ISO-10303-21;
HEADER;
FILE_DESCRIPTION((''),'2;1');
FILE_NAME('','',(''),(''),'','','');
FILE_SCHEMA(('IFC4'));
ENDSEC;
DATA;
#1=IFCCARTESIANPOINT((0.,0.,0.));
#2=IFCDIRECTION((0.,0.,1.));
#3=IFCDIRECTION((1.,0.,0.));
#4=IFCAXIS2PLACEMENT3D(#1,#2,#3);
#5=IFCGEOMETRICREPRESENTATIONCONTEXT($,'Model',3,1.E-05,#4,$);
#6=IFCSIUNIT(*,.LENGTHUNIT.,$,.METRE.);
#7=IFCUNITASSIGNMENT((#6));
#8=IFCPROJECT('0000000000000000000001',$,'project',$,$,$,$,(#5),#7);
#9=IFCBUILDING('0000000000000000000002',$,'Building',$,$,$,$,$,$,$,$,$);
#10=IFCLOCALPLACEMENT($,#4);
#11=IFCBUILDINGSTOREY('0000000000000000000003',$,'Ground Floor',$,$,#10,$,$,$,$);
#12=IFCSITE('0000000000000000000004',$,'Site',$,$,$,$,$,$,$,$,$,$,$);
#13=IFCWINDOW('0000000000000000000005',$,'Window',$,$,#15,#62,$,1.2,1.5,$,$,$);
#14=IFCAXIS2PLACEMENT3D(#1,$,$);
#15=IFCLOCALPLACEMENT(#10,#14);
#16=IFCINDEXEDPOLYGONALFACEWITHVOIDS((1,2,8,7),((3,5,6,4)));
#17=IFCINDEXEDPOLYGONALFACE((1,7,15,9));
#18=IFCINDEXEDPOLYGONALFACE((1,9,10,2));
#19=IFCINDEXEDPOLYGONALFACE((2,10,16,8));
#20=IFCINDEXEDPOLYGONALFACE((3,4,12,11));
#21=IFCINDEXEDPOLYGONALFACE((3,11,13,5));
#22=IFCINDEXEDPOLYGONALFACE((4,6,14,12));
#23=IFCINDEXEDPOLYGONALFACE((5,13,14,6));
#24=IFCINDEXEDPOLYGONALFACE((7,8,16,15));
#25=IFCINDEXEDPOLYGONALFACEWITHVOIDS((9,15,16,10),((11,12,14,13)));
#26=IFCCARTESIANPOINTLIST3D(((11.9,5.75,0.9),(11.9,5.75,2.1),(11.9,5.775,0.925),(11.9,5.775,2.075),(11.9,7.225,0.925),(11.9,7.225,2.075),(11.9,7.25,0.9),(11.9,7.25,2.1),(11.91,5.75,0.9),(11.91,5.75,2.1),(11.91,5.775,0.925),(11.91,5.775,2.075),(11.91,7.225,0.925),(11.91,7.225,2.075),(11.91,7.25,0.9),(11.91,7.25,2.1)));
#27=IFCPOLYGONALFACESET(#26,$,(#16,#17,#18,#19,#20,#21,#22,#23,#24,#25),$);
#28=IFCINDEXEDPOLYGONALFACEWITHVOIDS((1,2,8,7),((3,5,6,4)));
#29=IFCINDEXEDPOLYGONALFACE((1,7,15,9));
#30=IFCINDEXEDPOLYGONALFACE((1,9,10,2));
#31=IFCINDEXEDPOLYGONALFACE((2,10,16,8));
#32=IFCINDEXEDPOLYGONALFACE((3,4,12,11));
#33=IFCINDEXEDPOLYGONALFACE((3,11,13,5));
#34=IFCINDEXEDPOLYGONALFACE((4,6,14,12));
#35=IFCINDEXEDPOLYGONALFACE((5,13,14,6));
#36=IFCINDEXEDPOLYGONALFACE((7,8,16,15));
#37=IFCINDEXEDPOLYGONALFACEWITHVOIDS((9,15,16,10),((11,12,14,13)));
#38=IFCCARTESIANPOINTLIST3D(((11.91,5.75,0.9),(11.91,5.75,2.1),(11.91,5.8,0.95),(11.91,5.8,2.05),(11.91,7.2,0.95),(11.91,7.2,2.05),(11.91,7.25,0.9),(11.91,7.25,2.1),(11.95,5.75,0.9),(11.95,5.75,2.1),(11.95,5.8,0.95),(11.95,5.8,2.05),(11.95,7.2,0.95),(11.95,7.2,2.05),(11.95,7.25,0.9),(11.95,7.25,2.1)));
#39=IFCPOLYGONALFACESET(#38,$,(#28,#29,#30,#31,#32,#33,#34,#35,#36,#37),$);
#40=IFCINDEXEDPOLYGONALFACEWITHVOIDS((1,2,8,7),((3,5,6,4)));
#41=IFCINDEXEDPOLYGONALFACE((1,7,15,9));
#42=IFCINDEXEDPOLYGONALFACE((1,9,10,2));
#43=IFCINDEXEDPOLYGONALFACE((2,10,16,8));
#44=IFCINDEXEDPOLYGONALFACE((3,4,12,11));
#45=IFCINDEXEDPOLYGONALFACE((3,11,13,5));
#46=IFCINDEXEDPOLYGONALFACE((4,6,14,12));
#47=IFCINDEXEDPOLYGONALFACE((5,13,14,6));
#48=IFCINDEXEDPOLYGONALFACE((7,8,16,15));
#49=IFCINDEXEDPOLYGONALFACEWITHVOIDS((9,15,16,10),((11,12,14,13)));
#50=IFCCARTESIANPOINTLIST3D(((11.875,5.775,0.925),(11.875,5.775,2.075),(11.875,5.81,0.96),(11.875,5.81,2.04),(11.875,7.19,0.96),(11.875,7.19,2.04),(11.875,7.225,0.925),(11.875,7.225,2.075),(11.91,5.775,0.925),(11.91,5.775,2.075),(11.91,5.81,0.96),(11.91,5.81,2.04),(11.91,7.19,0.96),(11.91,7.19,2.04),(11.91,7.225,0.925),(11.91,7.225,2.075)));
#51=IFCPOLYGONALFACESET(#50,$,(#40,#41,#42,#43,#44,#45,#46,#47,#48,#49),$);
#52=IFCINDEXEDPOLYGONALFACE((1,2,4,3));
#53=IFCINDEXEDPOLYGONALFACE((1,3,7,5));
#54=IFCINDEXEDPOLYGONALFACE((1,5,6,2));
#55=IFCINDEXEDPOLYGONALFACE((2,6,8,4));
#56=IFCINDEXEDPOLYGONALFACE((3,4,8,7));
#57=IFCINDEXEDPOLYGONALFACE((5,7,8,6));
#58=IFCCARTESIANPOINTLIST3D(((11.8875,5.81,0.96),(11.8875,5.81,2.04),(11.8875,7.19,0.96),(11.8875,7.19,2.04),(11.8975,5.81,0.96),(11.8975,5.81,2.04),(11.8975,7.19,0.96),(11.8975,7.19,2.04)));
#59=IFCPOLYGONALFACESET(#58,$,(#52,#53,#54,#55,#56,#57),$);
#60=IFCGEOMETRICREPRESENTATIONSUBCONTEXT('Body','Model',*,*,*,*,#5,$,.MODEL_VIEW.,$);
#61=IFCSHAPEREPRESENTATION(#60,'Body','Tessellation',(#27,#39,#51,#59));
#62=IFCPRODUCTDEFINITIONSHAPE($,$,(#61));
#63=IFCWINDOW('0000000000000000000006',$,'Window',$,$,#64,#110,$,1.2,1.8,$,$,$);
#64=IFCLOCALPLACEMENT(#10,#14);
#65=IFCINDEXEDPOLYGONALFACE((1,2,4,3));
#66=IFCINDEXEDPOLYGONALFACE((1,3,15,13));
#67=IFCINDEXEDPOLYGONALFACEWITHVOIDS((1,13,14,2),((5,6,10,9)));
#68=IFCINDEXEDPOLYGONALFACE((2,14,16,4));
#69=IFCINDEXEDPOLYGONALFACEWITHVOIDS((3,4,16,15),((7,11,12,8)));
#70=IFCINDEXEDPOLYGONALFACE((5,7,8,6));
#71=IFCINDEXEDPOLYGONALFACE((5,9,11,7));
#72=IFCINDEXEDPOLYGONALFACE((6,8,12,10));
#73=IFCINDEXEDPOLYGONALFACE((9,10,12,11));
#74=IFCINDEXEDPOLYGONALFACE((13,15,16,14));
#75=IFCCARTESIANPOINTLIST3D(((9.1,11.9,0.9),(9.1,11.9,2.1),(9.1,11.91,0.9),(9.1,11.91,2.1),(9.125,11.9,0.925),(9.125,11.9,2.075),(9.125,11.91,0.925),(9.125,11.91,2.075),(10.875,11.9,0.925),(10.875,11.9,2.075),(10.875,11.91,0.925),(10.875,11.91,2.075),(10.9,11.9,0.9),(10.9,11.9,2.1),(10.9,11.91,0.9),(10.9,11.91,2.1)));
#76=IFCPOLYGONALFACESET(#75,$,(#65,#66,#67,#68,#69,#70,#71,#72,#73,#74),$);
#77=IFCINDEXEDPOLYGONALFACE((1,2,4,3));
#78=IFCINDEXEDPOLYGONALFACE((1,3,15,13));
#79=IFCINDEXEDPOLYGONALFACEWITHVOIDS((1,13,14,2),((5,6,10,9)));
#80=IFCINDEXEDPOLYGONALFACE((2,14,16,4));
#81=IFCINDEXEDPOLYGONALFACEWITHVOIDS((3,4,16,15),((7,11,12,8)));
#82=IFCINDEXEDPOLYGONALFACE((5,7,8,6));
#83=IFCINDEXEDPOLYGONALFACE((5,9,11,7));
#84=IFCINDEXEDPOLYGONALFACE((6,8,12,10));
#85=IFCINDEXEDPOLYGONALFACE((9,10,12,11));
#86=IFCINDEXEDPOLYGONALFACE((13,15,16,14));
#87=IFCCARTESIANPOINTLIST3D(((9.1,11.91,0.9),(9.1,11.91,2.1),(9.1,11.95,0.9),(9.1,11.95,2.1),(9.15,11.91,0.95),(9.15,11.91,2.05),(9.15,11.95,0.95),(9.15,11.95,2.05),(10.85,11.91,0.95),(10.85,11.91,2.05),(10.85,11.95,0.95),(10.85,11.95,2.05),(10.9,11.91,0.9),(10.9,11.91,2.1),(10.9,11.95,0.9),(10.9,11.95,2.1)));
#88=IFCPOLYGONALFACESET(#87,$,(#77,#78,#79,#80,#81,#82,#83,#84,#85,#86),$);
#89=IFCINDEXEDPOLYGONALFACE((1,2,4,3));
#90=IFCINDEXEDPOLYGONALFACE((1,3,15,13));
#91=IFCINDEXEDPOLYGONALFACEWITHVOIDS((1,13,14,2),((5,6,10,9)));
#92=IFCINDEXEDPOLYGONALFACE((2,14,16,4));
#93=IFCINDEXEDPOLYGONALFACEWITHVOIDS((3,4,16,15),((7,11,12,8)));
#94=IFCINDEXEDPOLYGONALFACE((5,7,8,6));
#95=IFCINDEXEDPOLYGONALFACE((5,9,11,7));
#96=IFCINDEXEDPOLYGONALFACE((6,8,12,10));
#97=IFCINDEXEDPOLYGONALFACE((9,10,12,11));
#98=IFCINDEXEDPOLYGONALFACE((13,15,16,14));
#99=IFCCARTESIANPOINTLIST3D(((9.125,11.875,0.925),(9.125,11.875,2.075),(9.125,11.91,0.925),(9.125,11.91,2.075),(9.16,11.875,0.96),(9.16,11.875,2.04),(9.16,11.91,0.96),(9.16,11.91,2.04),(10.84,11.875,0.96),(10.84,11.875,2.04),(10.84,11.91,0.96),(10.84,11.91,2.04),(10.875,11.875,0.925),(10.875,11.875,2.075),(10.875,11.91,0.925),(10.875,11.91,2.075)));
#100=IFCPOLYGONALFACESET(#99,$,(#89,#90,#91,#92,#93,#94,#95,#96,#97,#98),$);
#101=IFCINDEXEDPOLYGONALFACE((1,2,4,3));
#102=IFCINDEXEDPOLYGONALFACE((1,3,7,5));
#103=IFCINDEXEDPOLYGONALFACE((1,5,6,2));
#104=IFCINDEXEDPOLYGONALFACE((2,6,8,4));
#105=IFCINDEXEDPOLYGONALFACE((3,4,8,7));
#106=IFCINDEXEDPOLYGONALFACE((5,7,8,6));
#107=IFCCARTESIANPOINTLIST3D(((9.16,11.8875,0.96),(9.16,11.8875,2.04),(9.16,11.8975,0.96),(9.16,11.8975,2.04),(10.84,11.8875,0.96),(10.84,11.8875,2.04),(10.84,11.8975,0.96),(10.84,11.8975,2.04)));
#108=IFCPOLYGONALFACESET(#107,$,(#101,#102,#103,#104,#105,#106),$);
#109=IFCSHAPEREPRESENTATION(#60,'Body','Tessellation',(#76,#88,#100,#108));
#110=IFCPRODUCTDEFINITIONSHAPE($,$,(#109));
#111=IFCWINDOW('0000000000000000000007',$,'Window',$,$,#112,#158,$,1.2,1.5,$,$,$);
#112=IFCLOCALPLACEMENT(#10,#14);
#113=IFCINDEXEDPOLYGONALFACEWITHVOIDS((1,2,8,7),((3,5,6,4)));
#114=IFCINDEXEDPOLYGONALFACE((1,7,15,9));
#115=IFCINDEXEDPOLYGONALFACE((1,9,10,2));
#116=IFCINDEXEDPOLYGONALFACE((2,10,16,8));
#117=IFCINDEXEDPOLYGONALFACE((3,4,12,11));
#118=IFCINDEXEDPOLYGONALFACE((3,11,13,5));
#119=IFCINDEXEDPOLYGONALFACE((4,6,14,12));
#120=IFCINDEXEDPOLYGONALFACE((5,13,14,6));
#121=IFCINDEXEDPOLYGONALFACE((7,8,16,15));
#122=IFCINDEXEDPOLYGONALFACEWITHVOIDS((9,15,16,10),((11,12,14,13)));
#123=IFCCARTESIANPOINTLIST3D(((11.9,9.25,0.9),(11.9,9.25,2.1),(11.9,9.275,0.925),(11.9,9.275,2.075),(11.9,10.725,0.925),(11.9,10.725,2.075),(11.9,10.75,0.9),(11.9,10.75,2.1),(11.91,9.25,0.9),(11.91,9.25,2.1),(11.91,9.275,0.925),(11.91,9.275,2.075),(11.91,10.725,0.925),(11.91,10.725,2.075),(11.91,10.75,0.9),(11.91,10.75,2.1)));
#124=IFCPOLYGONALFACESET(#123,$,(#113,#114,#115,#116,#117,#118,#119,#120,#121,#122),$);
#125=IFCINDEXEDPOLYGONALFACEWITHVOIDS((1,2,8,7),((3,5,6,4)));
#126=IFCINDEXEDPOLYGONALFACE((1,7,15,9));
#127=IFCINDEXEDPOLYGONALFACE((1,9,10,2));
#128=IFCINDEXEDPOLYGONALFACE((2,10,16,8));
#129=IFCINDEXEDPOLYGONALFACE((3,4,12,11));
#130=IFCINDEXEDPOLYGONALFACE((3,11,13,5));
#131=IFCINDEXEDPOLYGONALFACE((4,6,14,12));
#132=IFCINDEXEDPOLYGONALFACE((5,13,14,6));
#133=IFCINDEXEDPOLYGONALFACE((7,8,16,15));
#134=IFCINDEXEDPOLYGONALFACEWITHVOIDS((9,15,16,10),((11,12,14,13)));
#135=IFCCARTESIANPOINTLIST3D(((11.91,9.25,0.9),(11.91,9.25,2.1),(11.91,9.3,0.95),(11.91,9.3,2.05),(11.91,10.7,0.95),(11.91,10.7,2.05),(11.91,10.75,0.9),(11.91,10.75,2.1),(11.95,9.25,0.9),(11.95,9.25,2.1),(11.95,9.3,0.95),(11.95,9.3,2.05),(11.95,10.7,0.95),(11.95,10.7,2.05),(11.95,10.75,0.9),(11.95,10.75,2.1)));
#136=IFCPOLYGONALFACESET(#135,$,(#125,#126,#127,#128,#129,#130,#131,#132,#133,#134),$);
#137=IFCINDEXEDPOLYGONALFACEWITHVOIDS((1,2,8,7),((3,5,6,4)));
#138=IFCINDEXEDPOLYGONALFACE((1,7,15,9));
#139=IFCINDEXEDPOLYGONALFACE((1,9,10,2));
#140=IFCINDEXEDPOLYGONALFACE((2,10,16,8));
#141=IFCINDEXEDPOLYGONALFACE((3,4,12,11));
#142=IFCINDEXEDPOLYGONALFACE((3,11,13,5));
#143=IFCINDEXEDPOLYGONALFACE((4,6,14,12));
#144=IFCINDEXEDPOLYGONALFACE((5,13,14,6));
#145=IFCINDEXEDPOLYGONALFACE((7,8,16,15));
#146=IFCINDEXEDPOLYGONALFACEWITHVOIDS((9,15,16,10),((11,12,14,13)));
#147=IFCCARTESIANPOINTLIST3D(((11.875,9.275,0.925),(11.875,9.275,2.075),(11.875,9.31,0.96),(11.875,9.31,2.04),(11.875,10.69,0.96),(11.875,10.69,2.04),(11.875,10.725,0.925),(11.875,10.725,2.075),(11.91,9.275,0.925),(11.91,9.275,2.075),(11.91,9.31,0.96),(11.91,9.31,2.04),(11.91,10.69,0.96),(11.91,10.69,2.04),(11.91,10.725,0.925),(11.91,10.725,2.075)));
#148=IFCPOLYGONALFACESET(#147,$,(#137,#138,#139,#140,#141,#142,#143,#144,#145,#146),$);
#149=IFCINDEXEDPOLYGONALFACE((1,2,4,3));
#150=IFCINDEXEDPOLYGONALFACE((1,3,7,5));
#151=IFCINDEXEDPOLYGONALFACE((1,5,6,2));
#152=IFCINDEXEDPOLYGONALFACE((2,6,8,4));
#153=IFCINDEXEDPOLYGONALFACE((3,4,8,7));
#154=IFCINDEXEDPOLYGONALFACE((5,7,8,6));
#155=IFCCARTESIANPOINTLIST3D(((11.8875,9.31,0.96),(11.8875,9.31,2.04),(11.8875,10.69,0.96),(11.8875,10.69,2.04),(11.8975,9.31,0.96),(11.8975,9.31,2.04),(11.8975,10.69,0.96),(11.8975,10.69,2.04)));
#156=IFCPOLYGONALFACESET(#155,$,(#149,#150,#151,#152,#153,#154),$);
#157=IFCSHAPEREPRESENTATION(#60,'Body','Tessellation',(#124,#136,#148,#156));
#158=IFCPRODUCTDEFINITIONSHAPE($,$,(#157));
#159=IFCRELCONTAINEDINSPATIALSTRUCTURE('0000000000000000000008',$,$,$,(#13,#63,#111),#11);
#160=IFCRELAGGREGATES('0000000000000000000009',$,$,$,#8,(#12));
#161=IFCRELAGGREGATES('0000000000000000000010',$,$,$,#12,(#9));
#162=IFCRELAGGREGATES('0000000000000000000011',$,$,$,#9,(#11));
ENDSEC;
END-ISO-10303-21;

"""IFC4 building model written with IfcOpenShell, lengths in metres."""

from ifc_helpers import new_model, si_unit, frame, origin_with_axes, place, context, subcontext, project, spatial, line, indexed_curve, outline, extrude, element, save


model = new_model("IFC4")

# Units and contexts
model_context = context("Model", 3, precision=1e-05, world=origin_with_axes())
body_context = subcontext(model_context, "Body", "Model", "MODEL_VIEW")
ifc_project = project(units=[si_unit("LENGTHUNIT", "METRE")], contexts=[model_context])

# Site, building, storey
site = spatial("IfcSite", under=ifc_project, Name="Site")
building = spatial("IfcBuilding", under=site, Name="Building")
storey_placement = place(None, origin_with_axes())
storey = spatial("IfcBuildingStorey", under=building, at=storey_placement, Name="Ground Floor")

# Windows
for number, where, z_axis, x_axis, name in (
    (1, (12.0, 5.75, 0.9), (0.0, 0.0, 1.0), (0.0, 1.0, 0.0), "Window"),
):
    element("IfcWindow", number, at=place(storey_placement, frame(where, z_axis=z_axis, x_axis=x_axis)), inside=storey, Name=name, OverallHeight=1.2, OverallWidth=1.5, context=body_context, shape_type="SweptSolid", body=[
        extrude(outline(indexed_curve([(0.0, 0.0), (1.5, 0.0), (1.5, 1.2), (0.0, 1.2)], segments=[line(1, 2, 3, 4, 1)]), holes=[indexed_curve([(0.025, 0.025), (1.475, 0.025), (1.475, 1.175), (0.025, 1.175)], segments=[line(1, 2, 3, 4, 1)])]), frame((0.0, 0.09, 0.0), z_axis=(0.0, -1.0, 0.0), x_axis=(1.0, 0.0, 0.0)), (0.0, 0.0, -1.0), 0.01),
        extrude(outline(indexed_curve([(0.0, 0.0), (1.5, 0.0), (1.5, 1.2), (0.0, 1.2)], segments=[line(1, 2, 3, 4, 1)]), holes=[indexed_curve([(0.05, 0.05), (1.45, 0.05), (1.45, 1.15), (0.05, 1.15)], segments=[line(1, 2, 3, 4, 1)])]), frame((0.0, 0.05, 0.0), z_axis=(0.0, -1.0, 0.0), x_axis=(1.0, 0.0, 0.0)), (0.0, 0.0, -1.0), 0.04),
        extrude(outline(indexed_curve([(0.0, 0.0), (1.45, 0.0), (1.45, 1.15), (0.0, 1.15)], segments=[line(1, 2, 3, 4, 1)]), holes=[indexed_curve([(0.035, 0.035), (1.415, 0.035), (1.415, 1.115), (0.035, 1.115)], segments=[line(1, 2, 3, 4, 1)])]), frame((0.025, 0.09, 0.025), z_axis=(0.0, -1.0, 0.0), x_axis=(1.0, 0.0, 0.0)), (0.0, 0.0, -1.0), 0.035),
        extrude(outline(indexed_curve([(0.035, 0.035), (1.415, 0.035), (1.415, 1.115), (0.035, 1.115)], segments=[line(1, 2, 3, 4, 1)])), frame((0.025, 0.1025, 0.025), z_axis=(0.0, -1.0, 0.0), x_axis=(1.0, 0.0, 0.0)), (0.0, 0.0, -1.0), 0.01),
    ])
window_1_placement = place(storey_placement, frame((10.9, 12.0, 0.9), z_axis=(0.0, 0.0, 1.0), x_axis=(-1.0, 0.0, 0.0)))
element("IfcWindow", 2, at=window_1_placement, inside=storey, Name="Window", OverallHeight=1.2, OverallWidth=1.8, context=body_context, shape_type="SweptSolid", body=[
    extrude(outline(indexed_curve([(0.0, 0.0), (1.8, 0.0), (1.8, 1.2), (0.0, 1.2)], segments=[line(1, 2, 3, 4, 1)]), holes=[indexed_curve([(0.025, 0.025), (1.775, 0.025), (1.775, 1.175), (0.025, 1.175)], segments=[line(1, 2, 3, 4, 1)])]), frame((0.0, 0.09, 0.0), z_axis=(0.0, -1.0, 0.0), x_axis=(1.0, 0.0, 0.0)), (0.0, 0.0, -1.0), 0.01),
    extrude(outline(indexed_curve([(0.0, 0.0), (1.8, 0.0), (1.8, 1.2), (0.0, 1.2)], segments=[line(1, 2, 3, 4, 1)]), holes=[indexed_curve([(0.05, 0.05), (1.75, 0.05), (1.75, 1.15), (0.05, 1.15)], segments=[line(1, 2, 3, 4, 1)])]), frame((0.0, 0.05, 0.0), z_axis=(0.0, -1.0, 0.0), x_axis=(1.0, 0.0, 0.0)), (0.0, 0.0, -1.0), 0.04),
    extrude(outline(indexed_curve([(0.0, 0.0), (1.75, 0.0), (1.75, 1.15), (0.0, 1.15)], segments=[line(1, 2, 3, 4, 1)]), holes=[indexed_curve([(0.035, 0.035), (1.715, 0.035), (1.715, 1.115), (0.035, 1.115)], segments=[line(1, 2, 3, 4, 1)])]), frame((0.025, 0.09, 0.025), z_axis=(0.0, -1.0, 0.0), x_axis=(1.0, 0.0, 0.0)), (0.0, 0.0, -1.0), 0.035),
    extrude(outline(indexed_curve([(0.035, 0.035), (1.715, 0.035), (1.715, 1.115), (0.035, 1.115)], segments=[line(1, 2, 3, 4, 1)])), frame((0.025, 0.1025, 0.025), z_axis=(0.0, -1.0, 0.0), x_axis=(1.0, 0.0, 0.0)), (0.0, 0.0, -1.0), 0.01),
])
window_2_placement = place(storey_placement, frame((12.0, 9.25, 0.9), z_axis=(0.0, 0.0, 1.0), x_axis=(0.0, 1.0, 0.0)))
element("IfcWindow", 3, at=window_2_placement, inside=storey, Name="Window", OverallHeight=1.2, OverallWidth=1.5, context=body_context, shape_type="SweptSolid", body=[
    extrude(outline(indexed_curve([(0.0, 0.0), (1.5, 0.0), (1.5, 1.2), (0.0, 1.2)], segments=[line(1, 2, 3, 4, 1)]), holes=[indexed_curve([(0.025, 0.025), (1.475, 0.025), (1.475, 1.175), (0.025, 1.175)], segments=[line(1, 2, 3, 4, 1)])]), frame((0.0, 0.09, 0.0), z_axis=(0.0, -1.0, 0.0), x_axis=(1.0, 0.0, 0.0)), (0.0, 0.0, -1.0), 0.01),
    extrude(outline(indexed_curve([(0.0, 0.0), (1.5, 0.0), (1.5, 1.2), (0.0, 1.2)], segments=[line(1, 2, 3, 4, 1)]), holes=[indexed_curve([(0.05, 0.05), (1.45, 0.05), (1.45, 1.15), (0.05, 1.15)], segments=[line(1, 2, 3, 4, 1)])]), frame((0.0, 0.05, 0.0), z_axis=(0.0, -1.0, 0.0), x_axis=(1.0, 0.0, 0.0)), (0.0, 0.0, -1.0), 0.04),
    extrude(outline(indexed_curve([(0.0, 0.0), (1.45, 0.0), (1.45, 1.15), (0.0, 1.15)], segments=[line(1, 2, 3, 4, 1)]), holes=[indexed_curve([(0.035, 0.035), (1.415, 0.035), (1.415, 1.115), (0.035, 1.115)], segments=[line(1, 2, 3, 4, 1)])]), frame((0.025, 0.09, 0.025), z_axis=(0.0, -1.0, 0.0), x_axis=(1.0, 0.0, 0.0)), (0.0, 0.0, -1.0), 0.035),
    extrude(outline(indexed_curve([(0.035, 0.035), (1.415, 0.035), (1.415, 1.115), (0.035, 1.115)], segments=[line(1, 2, 3, 4, 1)])), frame((0.025, 0.1025, 0.025), z_axis=(0.0, -1.0, 0.0), x_axis=(1.0, 0.0, 0.0)), (0.0, 0.0, -1.0), 0.01),
])

save(model, "model.ifc")
